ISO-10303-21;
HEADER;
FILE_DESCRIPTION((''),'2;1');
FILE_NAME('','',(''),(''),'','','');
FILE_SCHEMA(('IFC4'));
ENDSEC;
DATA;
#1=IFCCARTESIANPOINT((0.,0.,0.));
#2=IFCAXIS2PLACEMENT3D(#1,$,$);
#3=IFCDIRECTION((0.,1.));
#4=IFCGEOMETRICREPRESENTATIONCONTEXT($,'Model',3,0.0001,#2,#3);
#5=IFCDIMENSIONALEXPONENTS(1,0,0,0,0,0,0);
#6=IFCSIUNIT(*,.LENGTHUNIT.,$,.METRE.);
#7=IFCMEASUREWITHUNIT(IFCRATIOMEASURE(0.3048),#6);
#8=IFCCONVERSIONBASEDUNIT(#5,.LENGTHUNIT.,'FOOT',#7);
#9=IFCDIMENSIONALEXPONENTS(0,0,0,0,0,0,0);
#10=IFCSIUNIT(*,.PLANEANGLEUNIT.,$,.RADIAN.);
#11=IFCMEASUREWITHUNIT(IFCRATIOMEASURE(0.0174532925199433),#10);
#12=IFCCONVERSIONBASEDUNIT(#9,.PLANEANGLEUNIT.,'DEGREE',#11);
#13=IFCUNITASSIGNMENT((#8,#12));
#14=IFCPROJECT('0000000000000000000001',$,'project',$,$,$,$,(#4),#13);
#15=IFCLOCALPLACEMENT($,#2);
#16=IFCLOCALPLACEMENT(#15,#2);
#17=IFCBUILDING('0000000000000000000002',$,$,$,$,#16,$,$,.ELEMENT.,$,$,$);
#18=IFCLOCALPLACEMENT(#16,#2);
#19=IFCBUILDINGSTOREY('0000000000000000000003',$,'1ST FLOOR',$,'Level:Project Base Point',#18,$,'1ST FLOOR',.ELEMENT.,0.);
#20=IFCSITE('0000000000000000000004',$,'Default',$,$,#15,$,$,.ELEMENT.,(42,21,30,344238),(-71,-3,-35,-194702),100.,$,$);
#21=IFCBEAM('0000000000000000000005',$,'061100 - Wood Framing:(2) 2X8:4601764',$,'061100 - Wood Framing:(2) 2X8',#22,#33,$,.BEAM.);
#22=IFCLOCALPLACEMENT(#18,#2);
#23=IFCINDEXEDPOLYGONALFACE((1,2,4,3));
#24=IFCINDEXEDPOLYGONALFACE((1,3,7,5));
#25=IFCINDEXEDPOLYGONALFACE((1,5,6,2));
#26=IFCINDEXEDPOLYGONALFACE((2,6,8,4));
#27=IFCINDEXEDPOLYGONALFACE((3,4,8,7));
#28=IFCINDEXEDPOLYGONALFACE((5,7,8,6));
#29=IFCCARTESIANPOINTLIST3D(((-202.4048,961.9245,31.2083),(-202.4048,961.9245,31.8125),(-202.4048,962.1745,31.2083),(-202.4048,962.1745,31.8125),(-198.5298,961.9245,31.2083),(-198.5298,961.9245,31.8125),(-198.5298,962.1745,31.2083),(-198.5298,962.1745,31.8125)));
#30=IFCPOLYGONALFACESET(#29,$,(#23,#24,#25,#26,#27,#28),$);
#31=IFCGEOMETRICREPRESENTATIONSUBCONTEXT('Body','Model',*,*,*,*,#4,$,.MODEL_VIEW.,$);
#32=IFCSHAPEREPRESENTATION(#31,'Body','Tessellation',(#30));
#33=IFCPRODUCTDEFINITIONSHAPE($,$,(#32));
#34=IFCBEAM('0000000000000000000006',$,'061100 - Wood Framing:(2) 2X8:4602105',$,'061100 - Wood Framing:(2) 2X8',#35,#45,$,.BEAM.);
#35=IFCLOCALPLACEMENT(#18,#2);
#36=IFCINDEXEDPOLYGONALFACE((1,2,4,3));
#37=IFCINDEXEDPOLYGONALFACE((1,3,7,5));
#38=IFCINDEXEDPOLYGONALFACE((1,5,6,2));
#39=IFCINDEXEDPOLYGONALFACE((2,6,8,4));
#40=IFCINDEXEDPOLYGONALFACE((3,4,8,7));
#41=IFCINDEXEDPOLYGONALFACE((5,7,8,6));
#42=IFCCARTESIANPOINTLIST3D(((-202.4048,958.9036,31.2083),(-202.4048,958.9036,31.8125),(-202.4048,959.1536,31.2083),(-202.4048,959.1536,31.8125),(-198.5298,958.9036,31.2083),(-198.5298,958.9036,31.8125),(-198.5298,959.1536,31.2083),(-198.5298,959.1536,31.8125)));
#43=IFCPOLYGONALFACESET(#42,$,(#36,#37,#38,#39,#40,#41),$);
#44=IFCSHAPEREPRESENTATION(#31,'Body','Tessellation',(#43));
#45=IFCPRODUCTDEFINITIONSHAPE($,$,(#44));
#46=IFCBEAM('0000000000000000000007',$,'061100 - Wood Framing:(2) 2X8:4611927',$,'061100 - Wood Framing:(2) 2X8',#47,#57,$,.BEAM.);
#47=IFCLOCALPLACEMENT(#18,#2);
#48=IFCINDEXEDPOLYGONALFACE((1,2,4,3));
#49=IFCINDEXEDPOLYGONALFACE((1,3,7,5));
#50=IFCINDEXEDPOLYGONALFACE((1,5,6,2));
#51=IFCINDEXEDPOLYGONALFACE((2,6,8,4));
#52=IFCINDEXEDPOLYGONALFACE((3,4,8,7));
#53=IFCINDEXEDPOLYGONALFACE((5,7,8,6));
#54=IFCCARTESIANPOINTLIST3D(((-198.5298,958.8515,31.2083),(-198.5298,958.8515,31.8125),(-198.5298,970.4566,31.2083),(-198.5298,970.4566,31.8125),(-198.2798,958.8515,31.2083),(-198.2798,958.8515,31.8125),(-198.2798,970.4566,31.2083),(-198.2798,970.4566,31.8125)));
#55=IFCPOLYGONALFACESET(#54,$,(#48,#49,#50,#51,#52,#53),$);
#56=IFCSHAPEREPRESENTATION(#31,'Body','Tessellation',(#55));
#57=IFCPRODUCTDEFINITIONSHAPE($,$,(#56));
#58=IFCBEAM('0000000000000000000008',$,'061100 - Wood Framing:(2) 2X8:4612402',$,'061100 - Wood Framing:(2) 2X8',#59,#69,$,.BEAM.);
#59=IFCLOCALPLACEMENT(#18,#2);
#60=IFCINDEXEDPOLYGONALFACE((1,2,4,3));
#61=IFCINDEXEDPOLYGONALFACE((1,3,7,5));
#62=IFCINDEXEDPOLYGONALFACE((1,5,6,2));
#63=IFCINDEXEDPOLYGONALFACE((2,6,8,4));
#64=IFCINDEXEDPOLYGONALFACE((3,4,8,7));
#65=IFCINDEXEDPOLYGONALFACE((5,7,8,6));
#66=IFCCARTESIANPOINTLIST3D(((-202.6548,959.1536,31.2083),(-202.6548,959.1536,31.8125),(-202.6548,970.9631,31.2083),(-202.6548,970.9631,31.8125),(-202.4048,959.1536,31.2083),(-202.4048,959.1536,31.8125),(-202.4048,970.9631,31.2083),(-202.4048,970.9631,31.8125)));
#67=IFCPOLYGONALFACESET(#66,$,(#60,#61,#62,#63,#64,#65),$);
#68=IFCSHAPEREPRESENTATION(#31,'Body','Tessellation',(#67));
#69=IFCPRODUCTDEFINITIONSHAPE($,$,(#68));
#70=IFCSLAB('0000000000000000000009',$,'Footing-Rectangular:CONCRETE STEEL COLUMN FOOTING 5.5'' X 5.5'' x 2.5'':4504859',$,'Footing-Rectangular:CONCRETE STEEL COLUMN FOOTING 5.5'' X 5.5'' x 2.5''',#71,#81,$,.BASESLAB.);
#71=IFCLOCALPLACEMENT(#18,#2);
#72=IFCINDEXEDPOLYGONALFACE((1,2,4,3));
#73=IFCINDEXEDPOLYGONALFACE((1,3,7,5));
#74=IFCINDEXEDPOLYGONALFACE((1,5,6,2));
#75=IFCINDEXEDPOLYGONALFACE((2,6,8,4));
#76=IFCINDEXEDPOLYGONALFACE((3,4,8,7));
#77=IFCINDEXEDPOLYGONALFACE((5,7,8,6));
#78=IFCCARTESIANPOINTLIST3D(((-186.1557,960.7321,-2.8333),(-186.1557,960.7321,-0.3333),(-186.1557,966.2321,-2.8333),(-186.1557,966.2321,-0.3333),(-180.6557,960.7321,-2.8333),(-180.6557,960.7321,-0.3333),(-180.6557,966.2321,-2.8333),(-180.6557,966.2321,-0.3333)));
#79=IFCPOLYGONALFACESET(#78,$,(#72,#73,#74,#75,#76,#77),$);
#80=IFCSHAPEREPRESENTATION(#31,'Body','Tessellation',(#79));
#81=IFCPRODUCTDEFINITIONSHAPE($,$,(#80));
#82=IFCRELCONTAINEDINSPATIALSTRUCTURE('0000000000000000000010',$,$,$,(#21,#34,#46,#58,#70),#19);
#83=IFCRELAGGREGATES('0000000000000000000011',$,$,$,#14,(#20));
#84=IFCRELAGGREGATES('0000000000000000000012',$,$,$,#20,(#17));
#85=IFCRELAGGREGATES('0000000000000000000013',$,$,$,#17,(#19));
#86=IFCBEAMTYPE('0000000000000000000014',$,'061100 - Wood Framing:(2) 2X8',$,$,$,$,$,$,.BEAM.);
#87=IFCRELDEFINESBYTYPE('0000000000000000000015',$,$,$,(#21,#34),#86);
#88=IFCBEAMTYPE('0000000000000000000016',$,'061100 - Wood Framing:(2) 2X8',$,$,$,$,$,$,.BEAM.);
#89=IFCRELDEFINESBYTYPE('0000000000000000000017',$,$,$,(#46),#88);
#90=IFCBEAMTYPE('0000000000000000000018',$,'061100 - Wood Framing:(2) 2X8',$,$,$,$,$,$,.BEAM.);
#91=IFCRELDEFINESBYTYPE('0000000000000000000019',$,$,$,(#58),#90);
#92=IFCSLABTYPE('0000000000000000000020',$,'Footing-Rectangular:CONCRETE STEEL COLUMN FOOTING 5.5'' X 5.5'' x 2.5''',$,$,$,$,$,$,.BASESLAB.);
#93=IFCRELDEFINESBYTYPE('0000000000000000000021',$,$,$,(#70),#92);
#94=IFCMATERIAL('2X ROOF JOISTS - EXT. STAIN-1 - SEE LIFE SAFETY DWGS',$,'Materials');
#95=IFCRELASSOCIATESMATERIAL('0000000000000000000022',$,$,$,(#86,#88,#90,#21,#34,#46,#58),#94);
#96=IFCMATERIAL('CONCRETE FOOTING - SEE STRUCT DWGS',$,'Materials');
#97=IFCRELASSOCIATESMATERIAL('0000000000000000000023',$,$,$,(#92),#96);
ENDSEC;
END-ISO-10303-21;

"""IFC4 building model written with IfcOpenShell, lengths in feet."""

from ifc_helpers import new_model, entity, si_unit, converted_unit, direction, frame, frame_2d, origin, origin_2d_with_axis, place, context, subcontext, project, spatial, rectangle, extrude, source, transform, mapped, material, material_profile, profile_set, profile_usage, type_object, type_shapes, element, save


model = new_model("IFC4")

# Units and contexts
model_context = context("Model", 3, precision=0.0001, world=origin(), true_north=direction((0.0, 1.0)))
body_context = subcontext(model_context, "Body", "Model", "MODEL_VIEW")
ifc_project = project(units=[converted_unit("LENGTHUNIT", "FOOT", entity("IfcRatioMeasure", 0.3048), si_unit("LENGTHUNIT", "METRE"), dimensions=[1, 0, 0, 0, 0, 0, 0]), converted_unit("PLANEANGLEUNIT", "DEGREE", entity("IfcRatioMeasure", 0.0174532925199433), si_unit("PLANEANGLEUNIT", "RADIAN"), dimensions=[0, 0, 0, 0, 0, 0, 0])], contexts=[model_context])

# Site, building, storey
site_placement = place(None, origin())
site = spatial("IfcSite", under=ifc_project, at=site_placement, Name="Default", CompositionType="ELEMENT", RefLatitude=(42, 21, 30, 344238), RefLongitude=(-71, -3, -35, -194702), RefElevation=100.0)
building_placement = place(site_placement, origin())
building = spatial("IfcBuilding", under=site, at=building_placement, CompositionType="ELEMENT")
storey_placement = place(building_placement, origin())
storey = spatial("IfcBuildingStorey", under=building, at=storey_placement, Name="1ST FLOOR", ObjectType="Level:Project Base Point", LongName="1ST FLOOR", CompositionType="ELEMENT", Elevation=0.0)

# Beams
ifc_material_1 = material(Name="2X ROOF JOISTS - EXT. STAIN-1 - SEE LIFE SAFETY DWGS", Category="Materials")
ifc_material_profile_1 = material_profile(ifc_material_1, rectangle(XDim=0.6042, YDim=0.25, at=origin_2d_with_axis()), Name="(2) 2X8")
ifc_profile_set_1 = profile_set([ifc_material_profile_1], Name="(2) 2X8")
ifc_profile_usage_1 = profile_usage(ifc_profile_set_1, cardinal=8)
beam_type_1 = type_object("IfcBeamType", Name="061100 - Wood Framing:(2) 2X8", PredefinedType="BEAM", material=ifc_profile_set_1)
shared_shape_1 = source(origin(), body_context, "Body", "SweptSolid", [
    extrude(rectangle(XDim=0.6042, YDim=0.25, at=origin_2d_with_axis()), frame((-1.9375, 0.0, 0.0), z_axis=(1.0, 0.0, 0.0), x_axis=(0.0, 0.0, -1.0)), (0.0, 0.0, 1.0), 3.875),
])
type_shapes(beam_type_1, [shared_shape_1])
beam_1_placement = place(storey_placement, frame((-200.4673, 962.0495, 31.5104)))
element("IfcBeam", 1, at=beam_1_placement, inside=storey, type_object=beam_type_1, material=ifc_profile_usage_1, Name="061100 - Wood Framing:(2) 2X8:4601764", ObjectType="061100 - Wood Framing:(2) 2X8", PredefinedType="BEAM", context=body_context, shape_type="MappedRepresentation", body=[
    mapped(shared_shape_1, transform((0.0, 0.0, 0.0), scale=1.0)),
])
ifc_profile_usage_2 = profile_usage(ifc_profile_set_1, cardinal=8)
beam_2_placement = place(storey_placement, frame((-200.4673, 959.0286, 31.5104)))
element("IfcBeam", 2, at=beam_2_placement, inside=storey, type_object=beam_type_1, material=ifc_profile_usage_2, Name="061100 - Wood Framing:(2) 2X8:4602105", ObjectType="061100 - Wood Framing:(2) 2X8", PredefinedType="BEAM", context=body_context, shape_type="MappedRepresentation", body=[
    mapped(shared_shape_1, transform((0.0, 0.0, 0.0), scale=1.0)),
])
ifc_profile_usage_3 = profile_usage(ifc_profile_set_1, cardinal=8)
beam_type_2 = type_object("IfcBeamType", Name="061100 - Wood Framing:(2) 2X8", PredefinedType="BEAM", material=ifc_profile_set_1)
shared_shape_2 = source(origin(), body_context, "Body", "SweptSolid", [
    extrude(rectangle(XDim=0.6042, YDim=0.25, at=frame_2d((0.0, 0.0), x_axis=(1.0, 0.0))), frame((-5.714, 0.0, 0.0), z_axis=(1.0, 0.0, 0.0), x_axis=(0.0, 0.0, -1.0)), (0.0, 0.0, 1.0), 11.6051),
])
type_shapes(beam_type_2, [shared_shape_2])
beam_3_placement = place(storey_placement, frame((-198.4048, 964.7426, 31.5104), z_axis=(0.0, 0.0, 1.0), x_axis=(0.0, -1.0, 0.0)))
element("IfcBeam", 3, at=beam_3_placement, inside=storey, type_object=beam_type_2, material=ifc_profile_usage_3, Name="061100 - Wood Framing:(2) 2X8:4611927", ObjectType="061100 - Wood Framing:(2) 2X8", PredefinedType="BEAM", context=body_context, shape_type="MappedRepresentation", body=[
    mapped(shared_shape_2, transform((0.0, 0.0, 0.0), scale=1.0)),
])
ifc_profile_usage_4 = profile_usage(ifc_profile_set_1, cardinal=8)
beam_type_3 = type_object("IfcBeamType", Name="061100 - Wood Framing:(2) 2X8", PredefinedType="BEAM", material=ifc_profile_set_1)
shared_shape_3 = source(origin(), body_context, "Body", "SweptSolid", [
    extrude(rectangle(XDim=0.6042, YDim=0.25, at=frame_2d((0.0, 0.0), x_axis=(1.0, 0.0))), frame((-5.9673, 0.0, 0.0), z_axis=(1.0, 0.0, 0.0), x_axis=(0.0, 0.0, -1.0)), (0.0, 0.0, 1.0), 11.8095),
])
type_shapes(beam_type_3, [shared_shape_3])
beam_4_placement = place(storey_placement, frame((-202.5298, 964.9959, 31.5104), z_axis=(0.0, 0.0, 1.0), x_axis=(0.0, -1.0, 0.0)))
element("IfcBeam", 4, at=beam_4_placement, inside=storey, type_object=beam_type_3, material=ifc_profile_usage_4, Name="061100 - Wood Framing:(2) 2X8:4612402", ObjectType="061100 - Wood Framing:(2) 2X8", PredefinedType="BEAM", context=body_context, shape_type="MappedRepresentation", body=[
    mapped(shared_shape_3, transform((0.0, 0.0, 0.0), scale=1.0)),
])

# Slab
ifc_material_2 = material(Name="CONCRETE FOOTING - SEE STRUCT DWGS", Category="Materials")
slab_type = type_object("IfcSlabType", Name="Footing-Rectangular:CONCRETE STEEL COLUMN FOOTING 5.5' X 5.5' x 2.5'", PredefinedType="BASESLAB", material=ifc_material_2)
slab_placement = place(storey_placement, frame((-186.1557, 960.7321, -2.8333)))
element("IfcSlab", 5, at=slab_placement, inside=storey, type_object=slab_type, Name="Footing-Rectangular:CONCRETE STEEL COLUMN FOOTING 5.5' X 5.5' x 2.5':4504859", ObjectType="Footing-Rectangular:CONCRETE STEEL COLUMN FOOTING 5.5' X 5.5' x 2.5'", PredefinedType="BASESLAB", context=body_context, shape_type="SweptSolid", body=[
    extrude(rectangle(XDim=5.5, YDim=5.5, at=frame_2d((0.0, 0.0), x_axis=(1.0, 0.0))), frame((2.75, 2.75, 0.0), z_axis=(0.0, 0.0, 1.0), x_axis=(-1.0, 0.0, 0.0)), (0.0, 0.0, 1.0), 2.5),
])

save(model, "model.ifc")
